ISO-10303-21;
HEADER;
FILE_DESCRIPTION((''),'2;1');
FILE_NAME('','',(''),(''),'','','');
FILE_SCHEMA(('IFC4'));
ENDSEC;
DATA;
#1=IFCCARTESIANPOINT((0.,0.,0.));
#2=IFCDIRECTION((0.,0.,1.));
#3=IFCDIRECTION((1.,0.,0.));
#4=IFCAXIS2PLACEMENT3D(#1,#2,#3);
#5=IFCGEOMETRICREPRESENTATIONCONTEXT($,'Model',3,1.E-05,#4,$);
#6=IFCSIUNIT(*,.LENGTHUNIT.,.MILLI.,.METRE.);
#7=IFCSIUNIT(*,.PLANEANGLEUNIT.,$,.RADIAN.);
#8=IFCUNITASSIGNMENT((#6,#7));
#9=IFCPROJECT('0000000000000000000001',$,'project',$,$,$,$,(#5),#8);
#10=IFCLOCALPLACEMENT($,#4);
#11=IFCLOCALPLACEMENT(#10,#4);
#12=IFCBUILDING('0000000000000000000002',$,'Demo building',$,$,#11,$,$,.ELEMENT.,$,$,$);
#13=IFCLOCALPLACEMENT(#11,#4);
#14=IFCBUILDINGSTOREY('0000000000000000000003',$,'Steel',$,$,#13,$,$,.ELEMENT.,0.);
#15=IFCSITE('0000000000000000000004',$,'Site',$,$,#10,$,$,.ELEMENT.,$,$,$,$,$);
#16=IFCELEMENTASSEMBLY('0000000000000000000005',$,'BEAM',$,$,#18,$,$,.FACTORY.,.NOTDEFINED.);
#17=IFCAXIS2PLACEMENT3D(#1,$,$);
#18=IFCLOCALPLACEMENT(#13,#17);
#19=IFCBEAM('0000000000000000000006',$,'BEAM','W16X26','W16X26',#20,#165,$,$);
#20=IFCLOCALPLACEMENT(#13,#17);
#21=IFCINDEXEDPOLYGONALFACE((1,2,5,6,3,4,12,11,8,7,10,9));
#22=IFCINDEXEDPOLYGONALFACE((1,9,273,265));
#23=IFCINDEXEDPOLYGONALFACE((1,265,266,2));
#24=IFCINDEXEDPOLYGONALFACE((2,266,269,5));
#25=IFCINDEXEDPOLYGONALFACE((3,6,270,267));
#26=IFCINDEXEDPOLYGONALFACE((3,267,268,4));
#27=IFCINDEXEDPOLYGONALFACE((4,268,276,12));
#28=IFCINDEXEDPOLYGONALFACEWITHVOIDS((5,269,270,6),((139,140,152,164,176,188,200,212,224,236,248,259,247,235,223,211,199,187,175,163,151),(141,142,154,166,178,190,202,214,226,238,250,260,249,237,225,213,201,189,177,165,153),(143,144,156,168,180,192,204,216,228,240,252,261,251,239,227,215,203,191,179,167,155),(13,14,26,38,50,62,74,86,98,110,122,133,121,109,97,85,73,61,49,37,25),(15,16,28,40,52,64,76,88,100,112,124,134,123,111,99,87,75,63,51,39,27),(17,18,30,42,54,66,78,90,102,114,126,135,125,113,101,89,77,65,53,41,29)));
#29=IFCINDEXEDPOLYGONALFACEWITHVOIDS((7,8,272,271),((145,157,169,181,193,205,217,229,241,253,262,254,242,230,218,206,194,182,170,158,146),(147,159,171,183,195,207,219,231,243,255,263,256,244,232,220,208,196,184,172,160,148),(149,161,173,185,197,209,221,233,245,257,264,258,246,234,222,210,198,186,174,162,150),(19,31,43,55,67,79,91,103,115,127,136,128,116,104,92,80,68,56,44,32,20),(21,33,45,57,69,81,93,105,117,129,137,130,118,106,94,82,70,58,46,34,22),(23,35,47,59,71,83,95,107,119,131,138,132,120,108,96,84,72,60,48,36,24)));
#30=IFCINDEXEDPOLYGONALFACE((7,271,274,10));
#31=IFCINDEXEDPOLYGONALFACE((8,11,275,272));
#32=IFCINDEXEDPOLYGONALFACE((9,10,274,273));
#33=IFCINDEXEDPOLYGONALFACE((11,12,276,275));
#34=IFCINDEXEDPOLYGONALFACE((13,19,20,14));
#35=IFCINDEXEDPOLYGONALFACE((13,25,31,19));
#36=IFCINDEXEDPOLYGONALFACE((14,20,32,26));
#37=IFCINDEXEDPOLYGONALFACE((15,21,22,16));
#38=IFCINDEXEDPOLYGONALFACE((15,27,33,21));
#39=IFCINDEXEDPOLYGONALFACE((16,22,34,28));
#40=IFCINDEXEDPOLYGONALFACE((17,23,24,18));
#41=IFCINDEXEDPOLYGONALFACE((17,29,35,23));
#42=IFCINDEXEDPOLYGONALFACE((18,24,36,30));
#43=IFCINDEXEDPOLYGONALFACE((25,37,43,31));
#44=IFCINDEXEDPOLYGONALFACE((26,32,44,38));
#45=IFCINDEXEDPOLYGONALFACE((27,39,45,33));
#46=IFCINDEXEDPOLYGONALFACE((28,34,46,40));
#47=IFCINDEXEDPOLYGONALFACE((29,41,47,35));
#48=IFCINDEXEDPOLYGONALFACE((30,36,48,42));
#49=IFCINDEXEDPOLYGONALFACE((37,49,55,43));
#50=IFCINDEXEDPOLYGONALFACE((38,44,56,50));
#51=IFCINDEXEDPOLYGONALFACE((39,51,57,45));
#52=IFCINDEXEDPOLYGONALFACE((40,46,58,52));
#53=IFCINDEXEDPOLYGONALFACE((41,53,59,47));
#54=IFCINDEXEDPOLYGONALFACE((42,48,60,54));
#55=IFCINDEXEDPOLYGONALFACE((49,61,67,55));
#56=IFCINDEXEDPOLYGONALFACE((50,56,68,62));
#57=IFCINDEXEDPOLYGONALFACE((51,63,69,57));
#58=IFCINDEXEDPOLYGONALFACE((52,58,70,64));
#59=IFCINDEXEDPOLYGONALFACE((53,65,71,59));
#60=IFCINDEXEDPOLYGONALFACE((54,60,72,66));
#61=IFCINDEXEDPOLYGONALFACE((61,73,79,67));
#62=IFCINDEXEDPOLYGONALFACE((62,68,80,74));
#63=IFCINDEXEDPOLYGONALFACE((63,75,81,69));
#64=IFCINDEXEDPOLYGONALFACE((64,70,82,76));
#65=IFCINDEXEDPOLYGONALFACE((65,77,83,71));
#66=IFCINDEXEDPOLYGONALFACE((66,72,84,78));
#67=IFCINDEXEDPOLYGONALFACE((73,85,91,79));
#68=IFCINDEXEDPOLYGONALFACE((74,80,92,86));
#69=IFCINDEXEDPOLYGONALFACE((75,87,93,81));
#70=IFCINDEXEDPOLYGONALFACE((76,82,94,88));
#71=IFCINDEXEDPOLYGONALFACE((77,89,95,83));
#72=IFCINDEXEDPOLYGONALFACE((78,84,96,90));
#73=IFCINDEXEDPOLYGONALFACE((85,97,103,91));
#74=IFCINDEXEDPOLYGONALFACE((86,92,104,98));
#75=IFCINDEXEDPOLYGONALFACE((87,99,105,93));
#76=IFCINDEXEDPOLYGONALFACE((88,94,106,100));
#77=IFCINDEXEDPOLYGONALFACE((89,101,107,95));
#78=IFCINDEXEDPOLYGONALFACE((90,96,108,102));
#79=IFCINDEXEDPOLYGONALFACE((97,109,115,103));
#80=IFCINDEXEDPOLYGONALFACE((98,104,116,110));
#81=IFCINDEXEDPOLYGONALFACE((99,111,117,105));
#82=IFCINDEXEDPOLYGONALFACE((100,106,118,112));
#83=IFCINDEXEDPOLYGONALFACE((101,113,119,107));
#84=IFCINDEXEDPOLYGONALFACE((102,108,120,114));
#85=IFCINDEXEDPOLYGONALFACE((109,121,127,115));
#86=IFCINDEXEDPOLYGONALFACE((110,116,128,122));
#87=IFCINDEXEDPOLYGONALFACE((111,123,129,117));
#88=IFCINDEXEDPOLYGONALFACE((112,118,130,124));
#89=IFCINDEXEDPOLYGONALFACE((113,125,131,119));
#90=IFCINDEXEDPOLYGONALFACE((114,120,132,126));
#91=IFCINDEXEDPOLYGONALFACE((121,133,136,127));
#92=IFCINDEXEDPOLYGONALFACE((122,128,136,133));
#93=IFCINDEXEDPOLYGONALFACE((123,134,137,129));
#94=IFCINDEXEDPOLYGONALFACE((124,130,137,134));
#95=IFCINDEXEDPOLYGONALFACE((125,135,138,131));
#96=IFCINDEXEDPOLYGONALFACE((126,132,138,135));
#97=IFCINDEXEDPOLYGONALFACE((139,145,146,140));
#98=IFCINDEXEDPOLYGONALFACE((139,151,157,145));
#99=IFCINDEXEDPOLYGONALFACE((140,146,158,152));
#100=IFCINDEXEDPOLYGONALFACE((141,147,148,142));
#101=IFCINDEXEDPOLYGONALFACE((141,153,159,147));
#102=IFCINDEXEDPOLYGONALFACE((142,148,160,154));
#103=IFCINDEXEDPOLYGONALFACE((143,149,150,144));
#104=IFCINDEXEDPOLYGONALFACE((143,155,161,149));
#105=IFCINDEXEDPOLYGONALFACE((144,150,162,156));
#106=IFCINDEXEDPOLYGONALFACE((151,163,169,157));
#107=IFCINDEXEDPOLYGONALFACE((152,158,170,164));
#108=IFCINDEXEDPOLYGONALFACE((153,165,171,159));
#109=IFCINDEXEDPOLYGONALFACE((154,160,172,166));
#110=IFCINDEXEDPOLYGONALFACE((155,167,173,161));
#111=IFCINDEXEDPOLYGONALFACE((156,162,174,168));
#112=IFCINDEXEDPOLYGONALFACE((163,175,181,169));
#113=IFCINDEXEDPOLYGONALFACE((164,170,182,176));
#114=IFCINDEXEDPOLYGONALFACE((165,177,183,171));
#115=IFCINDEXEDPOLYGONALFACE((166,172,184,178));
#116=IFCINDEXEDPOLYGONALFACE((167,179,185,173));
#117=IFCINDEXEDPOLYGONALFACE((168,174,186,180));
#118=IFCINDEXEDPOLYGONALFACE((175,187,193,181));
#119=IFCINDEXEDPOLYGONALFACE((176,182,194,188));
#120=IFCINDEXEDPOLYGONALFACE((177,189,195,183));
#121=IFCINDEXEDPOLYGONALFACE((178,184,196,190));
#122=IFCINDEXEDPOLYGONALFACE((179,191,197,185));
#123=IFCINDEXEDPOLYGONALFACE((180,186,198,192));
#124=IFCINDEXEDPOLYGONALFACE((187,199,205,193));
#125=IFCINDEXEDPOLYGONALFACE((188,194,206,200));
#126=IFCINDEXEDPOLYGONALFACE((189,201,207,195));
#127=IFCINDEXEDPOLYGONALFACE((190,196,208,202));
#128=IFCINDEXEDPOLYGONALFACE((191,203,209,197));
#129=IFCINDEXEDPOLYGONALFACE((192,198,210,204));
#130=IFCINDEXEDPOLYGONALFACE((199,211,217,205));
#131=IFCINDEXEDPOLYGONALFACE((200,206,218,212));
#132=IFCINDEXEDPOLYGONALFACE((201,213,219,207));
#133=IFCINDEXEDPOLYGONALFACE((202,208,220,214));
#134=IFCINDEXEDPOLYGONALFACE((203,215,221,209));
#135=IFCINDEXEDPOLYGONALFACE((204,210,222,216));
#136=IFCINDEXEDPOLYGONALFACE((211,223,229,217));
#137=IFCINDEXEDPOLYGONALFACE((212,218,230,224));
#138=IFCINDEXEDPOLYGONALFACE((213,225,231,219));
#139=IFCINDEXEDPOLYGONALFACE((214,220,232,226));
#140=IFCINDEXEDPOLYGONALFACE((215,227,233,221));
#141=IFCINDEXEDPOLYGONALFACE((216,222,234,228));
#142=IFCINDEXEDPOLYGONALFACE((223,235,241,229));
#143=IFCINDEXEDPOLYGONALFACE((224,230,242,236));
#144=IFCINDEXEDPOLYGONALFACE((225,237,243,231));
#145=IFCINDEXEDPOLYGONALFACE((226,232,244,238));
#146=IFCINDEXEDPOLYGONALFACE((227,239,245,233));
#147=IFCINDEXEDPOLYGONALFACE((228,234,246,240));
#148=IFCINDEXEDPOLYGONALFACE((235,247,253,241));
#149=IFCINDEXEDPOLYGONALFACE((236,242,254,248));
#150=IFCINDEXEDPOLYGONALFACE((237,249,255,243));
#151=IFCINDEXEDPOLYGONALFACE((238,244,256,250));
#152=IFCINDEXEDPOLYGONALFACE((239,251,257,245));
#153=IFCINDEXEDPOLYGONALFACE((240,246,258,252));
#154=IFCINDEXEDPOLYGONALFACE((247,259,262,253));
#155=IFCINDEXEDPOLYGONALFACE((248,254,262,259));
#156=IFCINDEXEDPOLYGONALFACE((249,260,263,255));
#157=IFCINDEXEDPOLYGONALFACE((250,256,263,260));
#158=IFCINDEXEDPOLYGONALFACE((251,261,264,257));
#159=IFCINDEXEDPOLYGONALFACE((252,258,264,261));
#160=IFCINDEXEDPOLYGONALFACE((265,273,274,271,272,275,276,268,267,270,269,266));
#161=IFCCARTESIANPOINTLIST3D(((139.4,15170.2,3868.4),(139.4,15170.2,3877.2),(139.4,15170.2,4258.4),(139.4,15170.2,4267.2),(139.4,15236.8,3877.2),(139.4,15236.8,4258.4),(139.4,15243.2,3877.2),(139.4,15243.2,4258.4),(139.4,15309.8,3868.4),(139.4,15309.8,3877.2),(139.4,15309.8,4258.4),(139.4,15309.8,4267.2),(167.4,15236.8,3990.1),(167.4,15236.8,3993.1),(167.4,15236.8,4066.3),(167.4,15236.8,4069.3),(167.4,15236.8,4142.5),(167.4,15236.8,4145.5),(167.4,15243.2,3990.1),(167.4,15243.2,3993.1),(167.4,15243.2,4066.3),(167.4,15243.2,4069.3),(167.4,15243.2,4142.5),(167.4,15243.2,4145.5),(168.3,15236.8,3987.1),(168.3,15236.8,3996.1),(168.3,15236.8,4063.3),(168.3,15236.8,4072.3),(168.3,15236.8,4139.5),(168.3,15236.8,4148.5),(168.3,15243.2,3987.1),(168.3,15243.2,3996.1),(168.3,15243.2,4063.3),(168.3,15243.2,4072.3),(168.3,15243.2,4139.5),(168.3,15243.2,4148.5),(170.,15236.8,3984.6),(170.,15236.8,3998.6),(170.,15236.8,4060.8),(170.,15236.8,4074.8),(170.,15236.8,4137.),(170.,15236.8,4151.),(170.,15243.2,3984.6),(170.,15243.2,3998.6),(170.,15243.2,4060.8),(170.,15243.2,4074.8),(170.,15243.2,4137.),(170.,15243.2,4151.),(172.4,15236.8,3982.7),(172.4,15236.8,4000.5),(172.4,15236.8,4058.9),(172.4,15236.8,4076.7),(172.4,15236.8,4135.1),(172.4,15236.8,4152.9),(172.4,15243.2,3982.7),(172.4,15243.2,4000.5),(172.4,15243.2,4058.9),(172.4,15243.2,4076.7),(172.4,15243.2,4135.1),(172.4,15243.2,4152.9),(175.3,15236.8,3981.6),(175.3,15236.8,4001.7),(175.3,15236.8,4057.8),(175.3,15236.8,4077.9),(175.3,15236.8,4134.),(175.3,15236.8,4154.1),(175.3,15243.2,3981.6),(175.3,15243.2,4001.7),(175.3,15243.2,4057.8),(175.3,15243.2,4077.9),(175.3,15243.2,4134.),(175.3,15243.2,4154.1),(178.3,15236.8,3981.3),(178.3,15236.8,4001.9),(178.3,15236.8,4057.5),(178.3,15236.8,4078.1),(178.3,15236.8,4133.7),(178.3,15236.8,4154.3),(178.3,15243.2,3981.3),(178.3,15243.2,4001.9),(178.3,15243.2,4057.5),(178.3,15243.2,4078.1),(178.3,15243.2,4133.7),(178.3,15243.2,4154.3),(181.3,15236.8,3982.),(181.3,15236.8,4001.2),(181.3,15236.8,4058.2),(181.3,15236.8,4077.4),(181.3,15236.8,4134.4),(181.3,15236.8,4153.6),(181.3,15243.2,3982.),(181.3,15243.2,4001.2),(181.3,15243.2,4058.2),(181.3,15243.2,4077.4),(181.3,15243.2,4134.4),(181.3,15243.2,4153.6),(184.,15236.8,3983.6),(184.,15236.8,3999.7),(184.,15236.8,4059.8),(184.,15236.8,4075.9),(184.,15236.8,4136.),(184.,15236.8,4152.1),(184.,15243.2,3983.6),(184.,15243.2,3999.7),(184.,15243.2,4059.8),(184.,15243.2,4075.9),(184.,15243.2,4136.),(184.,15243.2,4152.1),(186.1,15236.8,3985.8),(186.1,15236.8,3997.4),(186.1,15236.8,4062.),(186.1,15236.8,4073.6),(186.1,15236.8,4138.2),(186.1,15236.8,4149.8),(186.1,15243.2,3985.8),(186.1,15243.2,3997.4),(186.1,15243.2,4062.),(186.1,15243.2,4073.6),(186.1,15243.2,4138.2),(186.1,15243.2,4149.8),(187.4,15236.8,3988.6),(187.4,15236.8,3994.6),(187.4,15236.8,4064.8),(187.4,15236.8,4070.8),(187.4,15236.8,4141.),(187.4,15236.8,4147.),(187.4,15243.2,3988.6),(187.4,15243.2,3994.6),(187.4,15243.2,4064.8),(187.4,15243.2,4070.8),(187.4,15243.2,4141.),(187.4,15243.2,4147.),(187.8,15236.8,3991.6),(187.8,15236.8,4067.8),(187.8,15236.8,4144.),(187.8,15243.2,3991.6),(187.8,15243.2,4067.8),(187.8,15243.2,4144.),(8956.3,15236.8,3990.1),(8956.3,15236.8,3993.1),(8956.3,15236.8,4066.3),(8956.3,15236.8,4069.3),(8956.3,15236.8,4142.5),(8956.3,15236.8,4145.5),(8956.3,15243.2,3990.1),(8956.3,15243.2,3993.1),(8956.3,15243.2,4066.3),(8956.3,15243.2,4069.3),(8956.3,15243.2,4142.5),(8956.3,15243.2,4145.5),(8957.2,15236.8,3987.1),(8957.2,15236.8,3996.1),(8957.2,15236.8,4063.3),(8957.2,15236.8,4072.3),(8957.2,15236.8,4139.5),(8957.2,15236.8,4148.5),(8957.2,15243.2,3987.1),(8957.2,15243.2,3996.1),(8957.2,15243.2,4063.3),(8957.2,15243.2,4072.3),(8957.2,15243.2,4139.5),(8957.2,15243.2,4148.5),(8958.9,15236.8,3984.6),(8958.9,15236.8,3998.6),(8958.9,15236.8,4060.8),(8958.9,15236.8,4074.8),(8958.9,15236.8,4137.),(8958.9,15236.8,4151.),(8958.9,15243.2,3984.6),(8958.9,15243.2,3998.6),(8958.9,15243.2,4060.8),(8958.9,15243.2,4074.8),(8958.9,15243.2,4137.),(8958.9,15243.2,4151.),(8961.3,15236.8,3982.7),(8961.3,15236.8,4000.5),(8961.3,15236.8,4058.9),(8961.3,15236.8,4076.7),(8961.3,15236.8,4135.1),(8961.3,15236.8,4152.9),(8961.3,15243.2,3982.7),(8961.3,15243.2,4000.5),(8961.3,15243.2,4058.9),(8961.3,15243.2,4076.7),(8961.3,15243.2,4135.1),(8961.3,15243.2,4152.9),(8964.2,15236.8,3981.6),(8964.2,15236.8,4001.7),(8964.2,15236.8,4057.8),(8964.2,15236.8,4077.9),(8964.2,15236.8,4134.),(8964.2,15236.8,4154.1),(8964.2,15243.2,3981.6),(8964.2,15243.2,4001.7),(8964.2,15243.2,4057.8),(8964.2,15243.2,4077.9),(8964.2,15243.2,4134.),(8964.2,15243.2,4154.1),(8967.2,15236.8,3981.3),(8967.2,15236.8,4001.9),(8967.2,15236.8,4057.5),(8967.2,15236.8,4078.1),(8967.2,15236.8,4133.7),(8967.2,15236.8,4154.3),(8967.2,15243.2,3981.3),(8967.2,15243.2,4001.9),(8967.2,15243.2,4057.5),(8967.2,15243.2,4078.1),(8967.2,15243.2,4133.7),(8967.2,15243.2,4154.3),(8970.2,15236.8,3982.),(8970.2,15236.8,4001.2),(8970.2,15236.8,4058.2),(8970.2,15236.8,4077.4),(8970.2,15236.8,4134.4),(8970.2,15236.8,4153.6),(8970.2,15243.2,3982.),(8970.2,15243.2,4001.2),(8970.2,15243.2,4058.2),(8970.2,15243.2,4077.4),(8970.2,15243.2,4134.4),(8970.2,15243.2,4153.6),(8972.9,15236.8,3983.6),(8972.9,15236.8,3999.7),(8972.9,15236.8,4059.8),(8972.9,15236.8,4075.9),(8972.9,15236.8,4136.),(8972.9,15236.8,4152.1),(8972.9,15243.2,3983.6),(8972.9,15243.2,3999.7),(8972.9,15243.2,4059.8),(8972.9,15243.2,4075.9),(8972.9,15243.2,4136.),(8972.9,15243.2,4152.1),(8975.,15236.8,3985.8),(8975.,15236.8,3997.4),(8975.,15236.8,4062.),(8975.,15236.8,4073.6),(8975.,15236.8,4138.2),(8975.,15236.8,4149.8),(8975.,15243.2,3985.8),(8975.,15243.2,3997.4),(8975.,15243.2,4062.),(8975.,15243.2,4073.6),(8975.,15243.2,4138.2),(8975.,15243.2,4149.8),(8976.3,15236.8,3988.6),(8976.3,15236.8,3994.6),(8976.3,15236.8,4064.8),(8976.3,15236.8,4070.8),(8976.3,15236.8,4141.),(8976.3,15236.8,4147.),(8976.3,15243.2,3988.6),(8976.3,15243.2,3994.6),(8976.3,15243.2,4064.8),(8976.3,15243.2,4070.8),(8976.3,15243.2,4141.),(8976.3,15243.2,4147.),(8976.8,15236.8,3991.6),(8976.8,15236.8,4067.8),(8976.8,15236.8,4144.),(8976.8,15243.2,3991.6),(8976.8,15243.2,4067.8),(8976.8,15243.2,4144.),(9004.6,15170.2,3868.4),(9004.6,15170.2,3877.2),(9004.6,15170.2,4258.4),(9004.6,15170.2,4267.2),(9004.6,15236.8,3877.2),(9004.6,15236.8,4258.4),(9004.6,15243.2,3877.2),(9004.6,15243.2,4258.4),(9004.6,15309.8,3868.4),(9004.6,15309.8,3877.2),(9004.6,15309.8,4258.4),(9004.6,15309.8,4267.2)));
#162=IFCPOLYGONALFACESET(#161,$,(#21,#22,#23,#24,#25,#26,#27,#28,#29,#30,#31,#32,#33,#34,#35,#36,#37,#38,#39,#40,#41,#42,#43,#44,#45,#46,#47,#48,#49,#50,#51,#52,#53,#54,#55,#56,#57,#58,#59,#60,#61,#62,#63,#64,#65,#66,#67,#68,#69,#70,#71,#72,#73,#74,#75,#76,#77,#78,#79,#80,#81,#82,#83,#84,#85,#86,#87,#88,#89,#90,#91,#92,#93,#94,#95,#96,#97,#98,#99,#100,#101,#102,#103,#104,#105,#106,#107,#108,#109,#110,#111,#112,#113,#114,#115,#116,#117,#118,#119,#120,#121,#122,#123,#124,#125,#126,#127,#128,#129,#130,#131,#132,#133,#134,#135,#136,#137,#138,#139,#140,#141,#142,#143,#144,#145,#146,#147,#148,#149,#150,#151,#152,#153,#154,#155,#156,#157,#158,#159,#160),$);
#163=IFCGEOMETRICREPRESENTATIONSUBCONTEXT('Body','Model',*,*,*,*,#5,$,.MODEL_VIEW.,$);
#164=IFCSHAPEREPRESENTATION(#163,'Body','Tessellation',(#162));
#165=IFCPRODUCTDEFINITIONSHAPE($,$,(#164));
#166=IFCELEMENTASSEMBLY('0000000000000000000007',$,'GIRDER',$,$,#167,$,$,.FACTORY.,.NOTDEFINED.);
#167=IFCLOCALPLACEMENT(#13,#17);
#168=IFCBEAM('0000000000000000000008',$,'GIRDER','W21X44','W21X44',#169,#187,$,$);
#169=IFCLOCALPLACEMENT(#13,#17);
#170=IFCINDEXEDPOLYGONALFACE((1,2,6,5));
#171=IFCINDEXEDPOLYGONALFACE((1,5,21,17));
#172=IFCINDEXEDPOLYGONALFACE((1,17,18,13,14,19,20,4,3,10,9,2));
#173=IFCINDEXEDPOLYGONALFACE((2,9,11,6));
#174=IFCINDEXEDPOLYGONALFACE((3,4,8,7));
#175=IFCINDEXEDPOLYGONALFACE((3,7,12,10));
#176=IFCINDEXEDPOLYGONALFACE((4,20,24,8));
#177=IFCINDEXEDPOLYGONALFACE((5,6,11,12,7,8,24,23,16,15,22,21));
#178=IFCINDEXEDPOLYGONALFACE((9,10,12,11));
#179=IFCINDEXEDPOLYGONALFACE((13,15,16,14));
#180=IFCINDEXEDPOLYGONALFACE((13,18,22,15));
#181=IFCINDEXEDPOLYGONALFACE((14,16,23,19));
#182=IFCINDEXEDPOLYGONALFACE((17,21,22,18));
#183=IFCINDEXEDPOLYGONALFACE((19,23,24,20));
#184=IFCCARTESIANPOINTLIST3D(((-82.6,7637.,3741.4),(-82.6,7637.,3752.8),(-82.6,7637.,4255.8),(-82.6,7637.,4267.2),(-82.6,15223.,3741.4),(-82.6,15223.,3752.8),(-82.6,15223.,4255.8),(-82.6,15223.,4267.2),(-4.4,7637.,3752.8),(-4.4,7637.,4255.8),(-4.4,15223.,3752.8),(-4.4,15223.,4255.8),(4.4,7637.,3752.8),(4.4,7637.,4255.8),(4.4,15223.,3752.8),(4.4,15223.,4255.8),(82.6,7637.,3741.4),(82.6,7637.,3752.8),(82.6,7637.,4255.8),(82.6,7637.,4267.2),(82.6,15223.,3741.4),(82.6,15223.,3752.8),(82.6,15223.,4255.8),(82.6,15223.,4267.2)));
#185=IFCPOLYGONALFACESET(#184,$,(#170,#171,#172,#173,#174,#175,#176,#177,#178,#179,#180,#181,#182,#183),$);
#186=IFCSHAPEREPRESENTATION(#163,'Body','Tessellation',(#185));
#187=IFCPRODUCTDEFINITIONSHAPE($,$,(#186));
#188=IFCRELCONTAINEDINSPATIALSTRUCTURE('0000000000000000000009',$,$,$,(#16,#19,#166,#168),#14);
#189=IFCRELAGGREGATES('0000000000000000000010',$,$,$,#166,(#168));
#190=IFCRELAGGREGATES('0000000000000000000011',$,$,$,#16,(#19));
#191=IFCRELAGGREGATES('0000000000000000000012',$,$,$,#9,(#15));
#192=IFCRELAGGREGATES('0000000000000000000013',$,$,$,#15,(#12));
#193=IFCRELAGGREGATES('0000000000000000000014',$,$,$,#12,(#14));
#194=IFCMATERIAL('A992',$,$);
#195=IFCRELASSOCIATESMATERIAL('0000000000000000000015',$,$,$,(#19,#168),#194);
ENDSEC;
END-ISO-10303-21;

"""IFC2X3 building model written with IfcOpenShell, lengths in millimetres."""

from ifc_helpers import new_model, si_unit, frame, origin, origin_with_axes, origin_2d, place, context, subcontext, project, spatial, circle, i_section, extrude, boolean, material, element, aggregate, save


model = new_model("IFC2X3")

# Units and contexts
model_context = context("Model", 3, precision=1e-05, world=origin_with_axes())
body_context = subcontext(model_context, "Body", "Model", "MODEL_VIEW")
ifc_project = project(units=[si_unit("LENGTHUNIT", "METRE", prefix="MILLI"), si_unit("PLANEANGLEUNIT", "RADIAN")], contexts=[model_context])

# Site, building, storey
site_placement = place(None, origin_with_axes())
site = spatial("IfcSite", under=ifc_project, at=site_placement, Name="Site", CompositionType="ELEMENT")
building_placement = place(site_placement, origin_with_axes())
building = spatial("IfcBuilding", under=site, at=building_placement, Name="Demo building", CompositionType="ELEMENT")
placement = place(building_placement, origin_with_axes())
storey = spatial("IfcBuildingStorey", under=building, at=placement, Name="Steel", CompositionType="ELEMENT", Elevation=0.0)

# Shared definitions
ifc_material_1 = material(Name="A992")

# Element assemblies, beams
assembly_1 = element("IfcElementAssembly", 1, at=placement, inside=storey, Name="BEAM", AssemblyPlace="FACTORY", PredefinedType="NOTDEFINED")
beam_1_placement = place(placement, frame((139.4, 15240.0, 4067.8), z_axis=(1.0, 0.0, 0.0), x_axis=(0.0, 1.0, 0.0)))
beam_1 = element("IfcBeam", 2, at=beam_1_placement, inside=storey, material=ifc_material_1, Name="BEAM", Description="W16X26", ObjectType="W16X26", context=body_context, shape_type="CSG", body=[
    boolean("DIFFERENCE", boolean("DIFFERENCE", boolean("DIFFERENCE", boolean("DIFFERENCE", boolean("DIFFERENCE", boolean("DIFFERENCE", extrude(i_section(OverallWidth=139.7, OverallDepth=398.8, WebThickness=6.3, FlangeThickness=8.8, at=origin_2d()), origin(), (0.0, 0.0, 1.0), 8865.1), extrude(circle(Radius=10.3, at=origin_2d()), frame((-60.0, -76.2, 38.1), z_axis=(1.0, 0.0, 0.0), x_axis=(0.0, 0.0, 1.0)), (0.0, 0.0, 1.0), 120.0)), extrude(circle(Radius=10.3, at=origin_2d()), frame((-60.0, 0.0, 38.1), z_axis=(1.0, 0.0, 0.0), x_axis=(0.0, 0.0, 1.0)), (0.0, 0.0, 1.0), 120.0)), extrude(circle(Radius=10.3, at=origin_2d()), frame((-60.0, 76.2, 38.1), z_axis=(1.0, 0.0, 0.0), x_axis=(0.0, 0.0, 1.0)), (0.0, 0.0, 1.0), 120.0)), extrude(circle(Radius=10.3, at=origin_2d()), frame((-60.0, -76.2, 8827.0), z_axis=(1.0, 0.0, 0.0), x_axis=(0.0, 0.0, 1.0)), (0.0, 0.0, 1.0), 120.0)), extrude(circle(Radius=10.3, at=origin_2d()), frame((-60.0, 0.0, 8827.0), z_axis=(1.0, 0.0, 0.0), x_axis=(0.0, 0.0, 1.0)), (0.0, 0.0, 1.0), 120.0)), extrude(circle(Radius=10.3, at=origin_2d()), frame((-60.0, 76.2, 8827.0), z_axis=(1.0, 0.0, 0.0), x_axis=(0.0, 0.0, 1.0)), (0.0, 0.0, 1.0), 120.0)),
])
assembly_2 = element("IfcElementAssembly", 3, at=placement, inside=storey, Name="GIRDER", AssemblyPlace="FACTORY", PredefinedType="NOTDEFINED")
beam_2_placement = place(placement, frame((0.0, 7637.0, 4004.3), z_axis=(0.0, 1.0, 0.0), x_axis=(-1.0, 0.0, 0.0)))
beam_2 = element("IfcBeam", 4, at=beam_2_placement, inside=storey, material=ifc_material_1, Name="GIRDER", Description="W21X44", ObjectType="W21X44", context=body_context, shape_type="SweptSolid", body=[
    extrude(i_section(OverallWidth=165.1, OverallDepth=525.8, WebThickness=8.9, FlangeThickness=11.4, at=origin_2d()), origin(), (0.0, 0.0, 1.0), 7586.0),
])
aggregate(assembly_2, [beam_2])

aggregate(assembly_1, [beam_1])

save(model, "model.ifc")
